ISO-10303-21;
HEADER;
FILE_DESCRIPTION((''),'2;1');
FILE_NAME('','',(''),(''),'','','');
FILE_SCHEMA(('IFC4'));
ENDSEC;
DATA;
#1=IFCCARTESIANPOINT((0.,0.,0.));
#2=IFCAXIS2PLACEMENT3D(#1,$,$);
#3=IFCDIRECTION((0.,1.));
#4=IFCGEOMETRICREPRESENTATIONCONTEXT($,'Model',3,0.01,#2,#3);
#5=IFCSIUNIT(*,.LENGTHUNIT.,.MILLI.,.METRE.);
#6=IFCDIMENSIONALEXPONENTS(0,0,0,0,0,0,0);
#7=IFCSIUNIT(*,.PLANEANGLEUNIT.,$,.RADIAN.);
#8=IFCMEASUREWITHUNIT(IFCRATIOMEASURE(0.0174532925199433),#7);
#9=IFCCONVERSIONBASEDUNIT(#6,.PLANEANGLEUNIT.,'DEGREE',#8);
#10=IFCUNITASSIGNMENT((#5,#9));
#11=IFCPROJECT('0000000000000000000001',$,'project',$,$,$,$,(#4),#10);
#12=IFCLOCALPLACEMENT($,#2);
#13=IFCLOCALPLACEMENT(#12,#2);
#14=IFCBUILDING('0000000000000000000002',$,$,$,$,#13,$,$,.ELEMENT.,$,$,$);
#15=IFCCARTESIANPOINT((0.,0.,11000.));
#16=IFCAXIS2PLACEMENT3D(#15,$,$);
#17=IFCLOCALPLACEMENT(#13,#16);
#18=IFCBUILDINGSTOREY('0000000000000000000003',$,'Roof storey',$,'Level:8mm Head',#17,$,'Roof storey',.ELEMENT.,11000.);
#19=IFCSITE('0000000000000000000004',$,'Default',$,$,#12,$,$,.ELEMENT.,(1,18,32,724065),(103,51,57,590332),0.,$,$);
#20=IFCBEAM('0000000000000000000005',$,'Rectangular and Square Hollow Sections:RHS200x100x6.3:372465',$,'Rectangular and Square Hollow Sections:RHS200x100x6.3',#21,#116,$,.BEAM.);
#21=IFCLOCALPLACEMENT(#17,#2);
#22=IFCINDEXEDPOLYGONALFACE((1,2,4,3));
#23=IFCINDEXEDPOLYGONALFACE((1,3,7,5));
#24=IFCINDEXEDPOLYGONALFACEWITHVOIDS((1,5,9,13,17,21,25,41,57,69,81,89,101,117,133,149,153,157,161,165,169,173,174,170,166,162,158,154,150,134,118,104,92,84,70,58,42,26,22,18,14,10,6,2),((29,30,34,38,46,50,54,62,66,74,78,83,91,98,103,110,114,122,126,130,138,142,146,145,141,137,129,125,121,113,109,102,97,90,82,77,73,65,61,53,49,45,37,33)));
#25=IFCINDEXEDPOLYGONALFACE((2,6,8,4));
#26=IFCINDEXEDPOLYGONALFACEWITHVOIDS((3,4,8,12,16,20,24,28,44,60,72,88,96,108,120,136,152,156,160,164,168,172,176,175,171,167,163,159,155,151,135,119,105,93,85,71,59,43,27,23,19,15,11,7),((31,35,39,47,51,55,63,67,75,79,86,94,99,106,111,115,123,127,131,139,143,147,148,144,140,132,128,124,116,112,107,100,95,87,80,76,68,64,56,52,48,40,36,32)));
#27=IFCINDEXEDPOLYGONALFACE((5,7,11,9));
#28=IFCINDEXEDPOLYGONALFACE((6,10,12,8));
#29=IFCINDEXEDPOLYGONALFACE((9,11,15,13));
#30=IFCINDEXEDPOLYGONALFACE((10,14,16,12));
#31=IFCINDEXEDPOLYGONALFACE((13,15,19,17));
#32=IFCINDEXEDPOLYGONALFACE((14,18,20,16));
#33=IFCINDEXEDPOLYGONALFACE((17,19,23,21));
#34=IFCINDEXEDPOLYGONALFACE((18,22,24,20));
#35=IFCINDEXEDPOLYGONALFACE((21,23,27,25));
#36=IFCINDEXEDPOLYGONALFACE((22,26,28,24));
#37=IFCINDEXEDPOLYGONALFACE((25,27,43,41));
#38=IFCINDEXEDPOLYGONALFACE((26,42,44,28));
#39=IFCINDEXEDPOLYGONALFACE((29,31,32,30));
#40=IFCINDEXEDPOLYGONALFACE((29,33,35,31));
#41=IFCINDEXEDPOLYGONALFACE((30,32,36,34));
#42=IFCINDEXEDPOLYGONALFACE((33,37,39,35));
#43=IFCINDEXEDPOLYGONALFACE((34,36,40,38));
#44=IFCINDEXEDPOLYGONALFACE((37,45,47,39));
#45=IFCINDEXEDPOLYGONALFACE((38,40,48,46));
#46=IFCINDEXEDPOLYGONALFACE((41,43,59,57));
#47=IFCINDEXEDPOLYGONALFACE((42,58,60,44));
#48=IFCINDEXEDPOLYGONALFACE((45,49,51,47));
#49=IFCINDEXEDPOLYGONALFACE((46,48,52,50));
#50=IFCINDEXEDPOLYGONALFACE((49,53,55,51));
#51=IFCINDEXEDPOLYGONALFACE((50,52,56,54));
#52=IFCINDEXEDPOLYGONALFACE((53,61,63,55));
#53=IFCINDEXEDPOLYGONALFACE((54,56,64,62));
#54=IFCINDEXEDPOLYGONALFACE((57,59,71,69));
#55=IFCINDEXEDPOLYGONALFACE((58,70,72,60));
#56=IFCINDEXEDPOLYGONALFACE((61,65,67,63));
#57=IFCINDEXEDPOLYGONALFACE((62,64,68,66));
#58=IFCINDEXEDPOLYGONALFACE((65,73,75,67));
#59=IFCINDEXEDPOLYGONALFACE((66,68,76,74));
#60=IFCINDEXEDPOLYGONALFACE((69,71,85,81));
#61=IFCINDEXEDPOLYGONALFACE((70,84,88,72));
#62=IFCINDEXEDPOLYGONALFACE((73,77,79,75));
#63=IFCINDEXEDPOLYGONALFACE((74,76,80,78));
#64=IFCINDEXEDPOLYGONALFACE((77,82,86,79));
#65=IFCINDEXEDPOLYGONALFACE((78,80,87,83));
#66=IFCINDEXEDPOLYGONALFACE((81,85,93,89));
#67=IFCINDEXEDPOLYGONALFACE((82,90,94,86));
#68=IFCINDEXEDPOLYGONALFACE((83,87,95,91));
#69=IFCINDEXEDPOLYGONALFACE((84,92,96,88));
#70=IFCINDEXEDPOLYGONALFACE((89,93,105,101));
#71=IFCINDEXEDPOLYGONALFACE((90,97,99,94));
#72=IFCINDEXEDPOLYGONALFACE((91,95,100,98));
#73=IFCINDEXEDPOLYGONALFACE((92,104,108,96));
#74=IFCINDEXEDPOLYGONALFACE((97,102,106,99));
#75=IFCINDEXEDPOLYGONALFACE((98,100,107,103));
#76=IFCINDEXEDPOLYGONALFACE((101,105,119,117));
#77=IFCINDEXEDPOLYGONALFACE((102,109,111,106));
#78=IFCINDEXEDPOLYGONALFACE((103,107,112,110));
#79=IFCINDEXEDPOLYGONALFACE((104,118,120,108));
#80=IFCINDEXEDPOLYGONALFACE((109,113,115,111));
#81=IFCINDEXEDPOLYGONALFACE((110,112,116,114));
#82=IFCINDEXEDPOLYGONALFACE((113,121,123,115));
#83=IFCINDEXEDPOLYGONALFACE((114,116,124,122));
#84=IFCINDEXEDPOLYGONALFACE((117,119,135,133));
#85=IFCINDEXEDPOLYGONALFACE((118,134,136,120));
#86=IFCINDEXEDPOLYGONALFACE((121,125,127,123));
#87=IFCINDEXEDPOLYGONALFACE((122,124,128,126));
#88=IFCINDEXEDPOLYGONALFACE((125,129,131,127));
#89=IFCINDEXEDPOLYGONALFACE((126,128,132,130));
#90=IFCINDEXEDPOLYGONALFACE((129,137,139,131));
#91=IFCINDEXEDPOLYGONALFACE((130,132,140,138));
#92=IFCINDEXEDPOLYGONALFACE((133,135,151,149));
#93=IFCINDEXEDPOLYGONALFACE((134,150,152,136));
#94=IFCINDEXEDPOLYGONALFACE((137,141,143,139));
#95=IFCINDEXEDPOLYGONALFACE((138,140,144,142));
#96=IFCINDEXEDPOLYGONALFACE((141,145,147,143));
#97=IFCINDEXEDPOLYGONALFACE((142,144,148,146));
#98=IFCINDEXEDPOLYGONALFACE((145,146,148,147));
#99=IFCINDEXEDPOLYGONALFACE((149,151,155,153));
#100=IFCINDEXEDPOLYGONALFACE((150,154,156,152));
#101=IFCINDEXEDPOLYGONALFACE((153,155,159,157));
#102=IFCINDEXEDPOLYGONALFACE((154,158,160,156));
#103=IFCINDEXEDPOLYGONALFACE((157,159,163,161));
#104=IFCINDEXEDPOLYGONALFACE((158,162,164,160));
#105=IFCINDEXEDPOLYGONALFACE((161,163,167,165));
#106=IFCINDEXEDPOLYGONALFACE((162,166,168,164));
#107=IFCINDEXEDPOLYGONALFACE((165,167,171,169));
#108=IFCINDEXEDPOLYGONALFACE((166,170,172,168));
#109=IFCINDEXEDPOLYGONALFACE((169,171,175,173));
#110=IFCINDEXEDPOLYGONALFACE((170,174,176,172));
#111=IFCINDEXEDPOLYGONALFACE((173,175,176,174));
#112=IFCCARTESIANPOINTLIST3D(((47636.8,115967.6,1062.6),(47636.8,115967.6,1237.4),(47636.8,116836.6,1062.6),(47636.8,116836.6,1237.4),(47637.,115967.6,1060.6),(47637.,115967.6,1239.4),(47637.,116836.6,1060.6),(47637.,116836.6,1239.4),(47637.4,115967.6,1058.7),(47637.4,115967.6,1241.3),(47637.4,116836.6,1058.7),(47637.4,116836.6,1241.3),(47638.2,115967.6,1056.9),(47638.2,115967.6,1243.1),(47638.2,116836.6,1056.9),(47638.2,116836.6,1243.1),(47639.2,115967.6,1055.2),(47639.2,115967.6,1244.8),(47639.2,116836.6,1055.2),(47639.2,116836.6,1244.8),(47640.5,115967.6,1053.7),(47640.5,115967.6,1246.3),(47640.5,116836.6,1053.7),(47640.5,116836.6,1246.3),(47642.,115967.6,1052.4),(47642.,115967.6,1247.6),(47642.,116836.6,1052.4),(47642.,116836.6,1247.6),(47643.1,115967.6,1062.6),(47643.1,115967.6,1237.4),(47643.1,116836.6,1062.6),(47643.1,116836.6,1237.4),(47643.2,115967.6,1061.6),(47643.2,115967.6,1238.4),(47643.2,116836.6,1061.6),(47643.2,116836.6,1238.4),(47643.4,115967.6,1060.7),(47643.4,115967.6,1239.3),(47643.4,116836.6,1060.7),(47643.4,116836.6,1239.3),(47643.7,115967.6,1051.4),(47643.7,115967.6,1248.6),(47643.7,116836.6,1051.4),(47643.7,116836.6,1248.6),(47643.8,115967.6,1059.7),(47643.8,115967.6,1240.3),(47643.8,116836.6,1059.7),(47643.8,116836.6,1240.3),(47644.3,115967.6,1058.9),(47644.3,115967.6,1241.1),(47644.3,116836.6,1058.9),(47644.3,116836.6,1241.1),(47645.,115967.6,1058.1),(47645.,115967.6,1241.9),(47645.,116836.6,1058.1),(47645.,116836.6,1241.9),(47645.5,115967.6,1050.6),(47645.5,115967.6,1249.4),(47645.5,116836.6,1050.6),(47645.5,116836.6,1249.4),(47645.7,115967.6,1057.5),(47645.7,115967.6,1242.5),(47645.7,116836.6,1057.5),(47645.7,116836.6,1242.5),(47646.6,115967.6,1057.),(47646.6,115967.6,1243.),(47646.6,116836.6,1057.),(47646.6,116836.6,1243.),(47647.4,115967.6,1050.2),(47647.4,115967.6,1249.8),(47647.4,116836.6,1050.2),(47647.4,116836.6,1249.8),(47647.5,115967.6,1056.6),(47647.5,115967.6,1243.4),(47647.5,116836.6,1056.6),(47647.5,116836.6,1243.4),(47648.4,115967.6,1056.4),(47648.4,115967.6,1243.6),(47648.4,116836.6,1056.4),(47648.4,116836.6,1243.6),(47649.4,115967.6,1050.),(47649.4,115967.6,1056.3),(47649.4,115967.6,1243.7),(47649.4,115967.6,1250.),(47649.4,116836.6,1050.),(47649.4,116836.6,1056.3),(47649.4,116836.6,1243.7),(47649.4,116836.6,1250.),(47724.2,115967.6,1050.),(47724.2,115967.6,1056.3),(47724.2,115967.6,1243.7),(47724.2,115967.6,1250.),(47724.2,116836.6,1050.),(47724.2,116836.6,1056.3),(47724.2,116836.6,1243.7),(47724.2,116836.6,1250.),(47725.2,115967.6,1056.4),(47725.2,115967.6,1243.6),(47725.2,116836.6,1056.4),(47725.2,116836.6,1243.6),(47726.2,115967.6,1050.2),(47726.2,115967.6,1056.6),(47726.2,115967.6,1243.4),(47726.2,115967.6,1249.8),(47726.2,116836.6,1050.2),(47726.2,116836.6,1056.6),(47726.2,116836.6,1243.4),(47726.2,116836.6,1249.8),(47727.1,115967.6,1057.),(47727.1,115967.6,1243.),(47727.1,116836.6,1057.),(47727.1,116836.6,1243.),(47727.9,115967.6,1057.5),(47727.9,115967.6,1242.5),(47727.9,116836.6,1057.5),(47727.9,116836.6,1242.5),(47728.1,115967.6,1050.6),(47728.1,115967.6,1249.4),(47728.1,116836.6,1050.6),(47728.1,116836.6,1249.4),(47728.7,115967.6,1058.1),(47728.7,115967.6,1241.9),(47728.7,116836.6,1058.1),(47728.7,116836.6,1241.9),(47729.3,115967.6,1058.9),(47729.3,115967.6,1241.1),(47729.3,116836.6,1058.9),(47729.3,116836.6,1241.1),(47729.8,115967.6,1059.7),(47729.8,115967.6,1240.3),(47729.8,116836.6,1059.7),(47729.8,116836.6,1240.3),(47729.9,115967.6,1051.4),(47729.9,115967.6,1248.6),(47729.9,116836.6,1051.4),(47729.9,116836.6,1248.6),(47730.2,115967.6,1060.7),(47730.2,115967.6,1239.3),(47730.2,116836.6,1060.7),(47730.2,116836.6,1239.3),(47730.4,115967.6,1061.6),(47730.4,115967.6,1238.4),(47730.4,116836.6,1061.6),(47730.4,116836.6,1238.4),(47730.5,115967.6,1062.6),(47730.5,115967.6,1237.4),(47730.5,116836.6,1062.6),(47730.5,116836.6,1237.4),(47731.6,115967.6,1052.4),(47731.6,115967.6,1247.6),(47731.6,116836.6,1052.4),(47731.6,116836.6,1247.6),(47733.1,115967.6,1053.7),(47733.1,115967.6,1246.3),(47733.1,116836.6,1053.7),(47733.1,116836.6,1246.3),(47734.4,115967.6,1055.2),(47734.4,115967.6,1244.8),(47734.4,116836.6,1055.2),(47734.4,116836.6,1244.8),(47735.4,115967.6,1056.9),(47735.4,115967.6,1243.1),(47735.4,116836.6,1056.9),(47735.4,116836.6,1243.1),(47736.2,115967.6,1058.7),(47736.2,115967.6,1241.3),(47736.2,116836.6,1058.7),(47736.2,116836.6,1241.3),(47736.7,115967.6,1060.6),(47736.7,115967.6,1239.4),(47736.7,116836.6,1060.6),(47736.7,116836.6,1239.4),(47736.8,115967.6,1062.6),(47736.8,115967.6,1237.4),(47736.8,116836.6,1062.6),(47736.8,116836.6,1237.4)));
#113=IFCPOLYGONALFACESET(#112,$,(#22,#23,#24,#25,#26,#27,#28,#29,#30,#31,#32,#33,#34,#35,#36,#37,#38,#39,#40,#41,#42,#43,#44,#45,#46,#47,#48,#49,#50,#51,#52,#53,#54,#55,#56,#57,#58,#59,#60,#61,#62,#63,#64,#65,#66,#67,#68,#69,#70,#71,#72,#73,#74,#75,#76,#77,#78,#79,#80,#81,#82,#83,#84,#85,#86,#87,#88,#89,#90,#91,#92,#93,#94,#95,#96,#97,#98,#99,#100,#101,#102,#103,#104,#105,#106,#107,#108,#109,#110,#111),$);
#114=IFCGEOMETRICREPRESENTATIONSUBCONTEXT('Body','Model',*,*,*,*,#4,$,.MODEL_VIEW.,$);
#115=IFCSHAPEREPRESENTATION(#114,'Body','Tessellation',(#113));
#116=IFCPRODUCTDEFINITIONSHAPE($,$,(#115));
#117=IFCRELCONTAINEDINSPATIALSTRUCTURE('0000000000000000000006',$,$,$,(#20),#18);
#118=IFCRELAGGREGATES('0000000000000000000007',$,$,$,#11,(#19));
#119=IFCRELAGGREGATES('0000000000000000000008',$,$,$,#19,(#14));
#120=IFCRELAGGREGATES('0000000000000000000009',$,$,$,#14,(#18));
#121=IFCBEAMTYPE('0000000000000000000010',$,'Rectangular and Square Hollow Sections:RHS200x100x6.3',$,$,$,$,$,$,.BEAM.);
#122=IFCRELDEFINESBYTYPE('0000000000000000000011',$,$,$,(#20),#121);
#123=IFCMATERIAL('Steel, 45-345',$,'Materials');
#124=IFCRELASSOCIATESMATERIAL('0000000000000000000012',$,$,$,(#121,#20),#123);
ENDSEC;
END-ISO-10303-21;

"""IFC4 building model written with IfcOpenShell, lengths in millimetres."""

from ifc_helpers import new_model, entity, si_unit, converted_unit, direction, frame, origin, place, context, subcontext, project, spatial, indexed_curve, outline, extrude, source, transform, mapped, material, type_object, type_shapes, element, save


model = new_model("IFC4")

# Units and contexts
model_context = context("Model", 3, precision=0.01, world=origin(), true_north=direction((0.0, 1.0)))
body_context = subcontext(model_context, "Body", "Model", "MODEL_VIEW")
ifc_project = project(units=[si_unit("LENGTHUNIT", "METRE", prefix="MILLI"), converted_unit("PLANEANGLEUNIT", "DEGREE", entity("IfcRatioMeasure", 0.0174532925199433), si_unit("PLANEANGLEUNIT", "RADIAN"), dimensions=[0, 0, 0, 0, 0, 0, 0])], contexts=[model_context])

# Site, building, storey
site_placement = place(None, origin())
site = spatial("IfcSite", under=ifc_project, at=site_placement, Name="Default", CompositionType="ELEMENT", RefLatitude=(1, 18, 32, 724065), RefLongitude=(103, 51, 57, 590332), RefElevation=0.0)
building_placement = place(site_placement, origin())
building = spatial("IfcBuilding", under=site, at=building_placement, CompositionType="ELEMENT")
storey_placement = place(building_placement, frame((0.0, 0.0, 11000.0)))
storey = spatial("IfcBuildingStorey", under=building, at=storey_placement, Name="Roof storey", ObjectType="Level:8mm Head", LongName="Roof storey", CompositionType="ELEMENT", Elevation=11000.0)

# Shared definitions
ifc_material = material(Name="Steel, 45-345", Category="Materials")

# Beam
beam_type_1 = type_object("IfcBeamType", Name="Rectangular and Square Hollow Sections:RHS200x100x6.3", PredefinedType="BEAM", material=ifc_material)
shared_shape_1 = source(origin(), body_context, "Body", "SweptSolid", [
    extrude(outline(indexed_curve([(87.4, -50.0), (89.4, -49.8), (91.3, -49.4), (93.1, -48.6), (94.8, -47.6), (96.3, -46.3), (97.6, -44.8), (98.6, -43.1), (99.4, -41.3), (99.8, -39.4), (100.0, -37.4), (100.0, 37.4), (99.8, 39.4), (99.4, 41.3), (98.6, 43.1), (97.6, 44.8), (96.3, 46.3), (94.8, 47.6), (93.1, 48.6), (91.3, 49.4), (89.4, 49.8), (87.4, 50.0), (-87.4, 50.0), (-89.4, 49.8), (-91.3, 49.4), (-93.1, 48.6), (-94.8, 47.6), (-96.3, 46.3), (-97.6, 44.8), (-98.6, 43.1), (-99.4, 41.3), (-99.8, 39.4), (-100.0, 37.4), (-100.0, -37.4), (-99.8, -39.4), (-99.4, -41.3), (-98.6, -43.1), (-97.6, -44.8), (-96.3, -46.3), (-94.8, -47.6), (-93.1, -48.6), (-91.3, -49.4), (-89.4, -49.8), (-87.4, -50.0), (87.4, -50.0)], self_intersect=False), holes=[indexed_curve([(93.7, 37.4), (93.7, -37.4), (93.6, -38.4), (93.4, -39.3), (93.0, -40.3), (92.5, -41.1), (91.9, -41.9), (91.1, -42.5), (90.3, -43.0), (89.3, -43.4), (88.4, -43.6), (87.4, -43.7), (-87.4, -43.7), (-88.4, -43.6), (-89.3, -43.4), (-90.3, -43.0), (-91.1, -42.5), (-91.9, -41.9), (-92.5, -41.1), (-93.0, -40.3), (-93.4, -39.3), (-93.6, -38.4), (-93.7, -37.4), (-93.7, 37.4), (-93.6, 38.4), (-93.4, 39.3), (-93.0, 40.3), (-92.5, 41.1), (-91.9, 41.9), (-91.1, 42.5), (-90.3, 43.0), (-89.3, 43.4), (-88.4, 43.6), (-87.4, 43.7), (87.4, 43.7), (88.4, 43.6), (89.3, 43.4), (90.3, 43.0), (91.1, 42.5), (91.9, 41.9), (92.5, 41.1), (93.0, 40.3), (93.4, 39.3), (93.6, 38.4), (93.7, 37.4)], self_intersect=False)]), frame((-412.0, 0.0, 0.0), z_axis=(1.0, 0.0, 0.0), x_axis=(0.0, 0.0, 1.0)), (0.0, 0.0, 1.0), 869.0),
])
type_shapes(beam_type_1, [shared_shape_1])
beam_1_placement = place(storey_placement, frame((47686.8, 116379.6, 1150.0), z_axis=(0.0, 0.0, 1.0), x_axis=(0.0, 1.0, 0.0)))
element("IfcBeam", 1, at=beam_1_placement, inside=storey, type_object=beam_type_1, material=ifc_material, Name="Rectangular and Square Hollow Sections:RHS200x100x6.3:372465", ObjectType="Rectangular and Square Hollow Sections:RHS200x100x6.3", PredefinedType="BEAM", context=body_context, shape_type="MappedRepresentation", body=[
    mapped(shared_shape_1, transform((0.0, 0.0, 0.0), scale=1.0)),
])

save(model, "model.ifc")
